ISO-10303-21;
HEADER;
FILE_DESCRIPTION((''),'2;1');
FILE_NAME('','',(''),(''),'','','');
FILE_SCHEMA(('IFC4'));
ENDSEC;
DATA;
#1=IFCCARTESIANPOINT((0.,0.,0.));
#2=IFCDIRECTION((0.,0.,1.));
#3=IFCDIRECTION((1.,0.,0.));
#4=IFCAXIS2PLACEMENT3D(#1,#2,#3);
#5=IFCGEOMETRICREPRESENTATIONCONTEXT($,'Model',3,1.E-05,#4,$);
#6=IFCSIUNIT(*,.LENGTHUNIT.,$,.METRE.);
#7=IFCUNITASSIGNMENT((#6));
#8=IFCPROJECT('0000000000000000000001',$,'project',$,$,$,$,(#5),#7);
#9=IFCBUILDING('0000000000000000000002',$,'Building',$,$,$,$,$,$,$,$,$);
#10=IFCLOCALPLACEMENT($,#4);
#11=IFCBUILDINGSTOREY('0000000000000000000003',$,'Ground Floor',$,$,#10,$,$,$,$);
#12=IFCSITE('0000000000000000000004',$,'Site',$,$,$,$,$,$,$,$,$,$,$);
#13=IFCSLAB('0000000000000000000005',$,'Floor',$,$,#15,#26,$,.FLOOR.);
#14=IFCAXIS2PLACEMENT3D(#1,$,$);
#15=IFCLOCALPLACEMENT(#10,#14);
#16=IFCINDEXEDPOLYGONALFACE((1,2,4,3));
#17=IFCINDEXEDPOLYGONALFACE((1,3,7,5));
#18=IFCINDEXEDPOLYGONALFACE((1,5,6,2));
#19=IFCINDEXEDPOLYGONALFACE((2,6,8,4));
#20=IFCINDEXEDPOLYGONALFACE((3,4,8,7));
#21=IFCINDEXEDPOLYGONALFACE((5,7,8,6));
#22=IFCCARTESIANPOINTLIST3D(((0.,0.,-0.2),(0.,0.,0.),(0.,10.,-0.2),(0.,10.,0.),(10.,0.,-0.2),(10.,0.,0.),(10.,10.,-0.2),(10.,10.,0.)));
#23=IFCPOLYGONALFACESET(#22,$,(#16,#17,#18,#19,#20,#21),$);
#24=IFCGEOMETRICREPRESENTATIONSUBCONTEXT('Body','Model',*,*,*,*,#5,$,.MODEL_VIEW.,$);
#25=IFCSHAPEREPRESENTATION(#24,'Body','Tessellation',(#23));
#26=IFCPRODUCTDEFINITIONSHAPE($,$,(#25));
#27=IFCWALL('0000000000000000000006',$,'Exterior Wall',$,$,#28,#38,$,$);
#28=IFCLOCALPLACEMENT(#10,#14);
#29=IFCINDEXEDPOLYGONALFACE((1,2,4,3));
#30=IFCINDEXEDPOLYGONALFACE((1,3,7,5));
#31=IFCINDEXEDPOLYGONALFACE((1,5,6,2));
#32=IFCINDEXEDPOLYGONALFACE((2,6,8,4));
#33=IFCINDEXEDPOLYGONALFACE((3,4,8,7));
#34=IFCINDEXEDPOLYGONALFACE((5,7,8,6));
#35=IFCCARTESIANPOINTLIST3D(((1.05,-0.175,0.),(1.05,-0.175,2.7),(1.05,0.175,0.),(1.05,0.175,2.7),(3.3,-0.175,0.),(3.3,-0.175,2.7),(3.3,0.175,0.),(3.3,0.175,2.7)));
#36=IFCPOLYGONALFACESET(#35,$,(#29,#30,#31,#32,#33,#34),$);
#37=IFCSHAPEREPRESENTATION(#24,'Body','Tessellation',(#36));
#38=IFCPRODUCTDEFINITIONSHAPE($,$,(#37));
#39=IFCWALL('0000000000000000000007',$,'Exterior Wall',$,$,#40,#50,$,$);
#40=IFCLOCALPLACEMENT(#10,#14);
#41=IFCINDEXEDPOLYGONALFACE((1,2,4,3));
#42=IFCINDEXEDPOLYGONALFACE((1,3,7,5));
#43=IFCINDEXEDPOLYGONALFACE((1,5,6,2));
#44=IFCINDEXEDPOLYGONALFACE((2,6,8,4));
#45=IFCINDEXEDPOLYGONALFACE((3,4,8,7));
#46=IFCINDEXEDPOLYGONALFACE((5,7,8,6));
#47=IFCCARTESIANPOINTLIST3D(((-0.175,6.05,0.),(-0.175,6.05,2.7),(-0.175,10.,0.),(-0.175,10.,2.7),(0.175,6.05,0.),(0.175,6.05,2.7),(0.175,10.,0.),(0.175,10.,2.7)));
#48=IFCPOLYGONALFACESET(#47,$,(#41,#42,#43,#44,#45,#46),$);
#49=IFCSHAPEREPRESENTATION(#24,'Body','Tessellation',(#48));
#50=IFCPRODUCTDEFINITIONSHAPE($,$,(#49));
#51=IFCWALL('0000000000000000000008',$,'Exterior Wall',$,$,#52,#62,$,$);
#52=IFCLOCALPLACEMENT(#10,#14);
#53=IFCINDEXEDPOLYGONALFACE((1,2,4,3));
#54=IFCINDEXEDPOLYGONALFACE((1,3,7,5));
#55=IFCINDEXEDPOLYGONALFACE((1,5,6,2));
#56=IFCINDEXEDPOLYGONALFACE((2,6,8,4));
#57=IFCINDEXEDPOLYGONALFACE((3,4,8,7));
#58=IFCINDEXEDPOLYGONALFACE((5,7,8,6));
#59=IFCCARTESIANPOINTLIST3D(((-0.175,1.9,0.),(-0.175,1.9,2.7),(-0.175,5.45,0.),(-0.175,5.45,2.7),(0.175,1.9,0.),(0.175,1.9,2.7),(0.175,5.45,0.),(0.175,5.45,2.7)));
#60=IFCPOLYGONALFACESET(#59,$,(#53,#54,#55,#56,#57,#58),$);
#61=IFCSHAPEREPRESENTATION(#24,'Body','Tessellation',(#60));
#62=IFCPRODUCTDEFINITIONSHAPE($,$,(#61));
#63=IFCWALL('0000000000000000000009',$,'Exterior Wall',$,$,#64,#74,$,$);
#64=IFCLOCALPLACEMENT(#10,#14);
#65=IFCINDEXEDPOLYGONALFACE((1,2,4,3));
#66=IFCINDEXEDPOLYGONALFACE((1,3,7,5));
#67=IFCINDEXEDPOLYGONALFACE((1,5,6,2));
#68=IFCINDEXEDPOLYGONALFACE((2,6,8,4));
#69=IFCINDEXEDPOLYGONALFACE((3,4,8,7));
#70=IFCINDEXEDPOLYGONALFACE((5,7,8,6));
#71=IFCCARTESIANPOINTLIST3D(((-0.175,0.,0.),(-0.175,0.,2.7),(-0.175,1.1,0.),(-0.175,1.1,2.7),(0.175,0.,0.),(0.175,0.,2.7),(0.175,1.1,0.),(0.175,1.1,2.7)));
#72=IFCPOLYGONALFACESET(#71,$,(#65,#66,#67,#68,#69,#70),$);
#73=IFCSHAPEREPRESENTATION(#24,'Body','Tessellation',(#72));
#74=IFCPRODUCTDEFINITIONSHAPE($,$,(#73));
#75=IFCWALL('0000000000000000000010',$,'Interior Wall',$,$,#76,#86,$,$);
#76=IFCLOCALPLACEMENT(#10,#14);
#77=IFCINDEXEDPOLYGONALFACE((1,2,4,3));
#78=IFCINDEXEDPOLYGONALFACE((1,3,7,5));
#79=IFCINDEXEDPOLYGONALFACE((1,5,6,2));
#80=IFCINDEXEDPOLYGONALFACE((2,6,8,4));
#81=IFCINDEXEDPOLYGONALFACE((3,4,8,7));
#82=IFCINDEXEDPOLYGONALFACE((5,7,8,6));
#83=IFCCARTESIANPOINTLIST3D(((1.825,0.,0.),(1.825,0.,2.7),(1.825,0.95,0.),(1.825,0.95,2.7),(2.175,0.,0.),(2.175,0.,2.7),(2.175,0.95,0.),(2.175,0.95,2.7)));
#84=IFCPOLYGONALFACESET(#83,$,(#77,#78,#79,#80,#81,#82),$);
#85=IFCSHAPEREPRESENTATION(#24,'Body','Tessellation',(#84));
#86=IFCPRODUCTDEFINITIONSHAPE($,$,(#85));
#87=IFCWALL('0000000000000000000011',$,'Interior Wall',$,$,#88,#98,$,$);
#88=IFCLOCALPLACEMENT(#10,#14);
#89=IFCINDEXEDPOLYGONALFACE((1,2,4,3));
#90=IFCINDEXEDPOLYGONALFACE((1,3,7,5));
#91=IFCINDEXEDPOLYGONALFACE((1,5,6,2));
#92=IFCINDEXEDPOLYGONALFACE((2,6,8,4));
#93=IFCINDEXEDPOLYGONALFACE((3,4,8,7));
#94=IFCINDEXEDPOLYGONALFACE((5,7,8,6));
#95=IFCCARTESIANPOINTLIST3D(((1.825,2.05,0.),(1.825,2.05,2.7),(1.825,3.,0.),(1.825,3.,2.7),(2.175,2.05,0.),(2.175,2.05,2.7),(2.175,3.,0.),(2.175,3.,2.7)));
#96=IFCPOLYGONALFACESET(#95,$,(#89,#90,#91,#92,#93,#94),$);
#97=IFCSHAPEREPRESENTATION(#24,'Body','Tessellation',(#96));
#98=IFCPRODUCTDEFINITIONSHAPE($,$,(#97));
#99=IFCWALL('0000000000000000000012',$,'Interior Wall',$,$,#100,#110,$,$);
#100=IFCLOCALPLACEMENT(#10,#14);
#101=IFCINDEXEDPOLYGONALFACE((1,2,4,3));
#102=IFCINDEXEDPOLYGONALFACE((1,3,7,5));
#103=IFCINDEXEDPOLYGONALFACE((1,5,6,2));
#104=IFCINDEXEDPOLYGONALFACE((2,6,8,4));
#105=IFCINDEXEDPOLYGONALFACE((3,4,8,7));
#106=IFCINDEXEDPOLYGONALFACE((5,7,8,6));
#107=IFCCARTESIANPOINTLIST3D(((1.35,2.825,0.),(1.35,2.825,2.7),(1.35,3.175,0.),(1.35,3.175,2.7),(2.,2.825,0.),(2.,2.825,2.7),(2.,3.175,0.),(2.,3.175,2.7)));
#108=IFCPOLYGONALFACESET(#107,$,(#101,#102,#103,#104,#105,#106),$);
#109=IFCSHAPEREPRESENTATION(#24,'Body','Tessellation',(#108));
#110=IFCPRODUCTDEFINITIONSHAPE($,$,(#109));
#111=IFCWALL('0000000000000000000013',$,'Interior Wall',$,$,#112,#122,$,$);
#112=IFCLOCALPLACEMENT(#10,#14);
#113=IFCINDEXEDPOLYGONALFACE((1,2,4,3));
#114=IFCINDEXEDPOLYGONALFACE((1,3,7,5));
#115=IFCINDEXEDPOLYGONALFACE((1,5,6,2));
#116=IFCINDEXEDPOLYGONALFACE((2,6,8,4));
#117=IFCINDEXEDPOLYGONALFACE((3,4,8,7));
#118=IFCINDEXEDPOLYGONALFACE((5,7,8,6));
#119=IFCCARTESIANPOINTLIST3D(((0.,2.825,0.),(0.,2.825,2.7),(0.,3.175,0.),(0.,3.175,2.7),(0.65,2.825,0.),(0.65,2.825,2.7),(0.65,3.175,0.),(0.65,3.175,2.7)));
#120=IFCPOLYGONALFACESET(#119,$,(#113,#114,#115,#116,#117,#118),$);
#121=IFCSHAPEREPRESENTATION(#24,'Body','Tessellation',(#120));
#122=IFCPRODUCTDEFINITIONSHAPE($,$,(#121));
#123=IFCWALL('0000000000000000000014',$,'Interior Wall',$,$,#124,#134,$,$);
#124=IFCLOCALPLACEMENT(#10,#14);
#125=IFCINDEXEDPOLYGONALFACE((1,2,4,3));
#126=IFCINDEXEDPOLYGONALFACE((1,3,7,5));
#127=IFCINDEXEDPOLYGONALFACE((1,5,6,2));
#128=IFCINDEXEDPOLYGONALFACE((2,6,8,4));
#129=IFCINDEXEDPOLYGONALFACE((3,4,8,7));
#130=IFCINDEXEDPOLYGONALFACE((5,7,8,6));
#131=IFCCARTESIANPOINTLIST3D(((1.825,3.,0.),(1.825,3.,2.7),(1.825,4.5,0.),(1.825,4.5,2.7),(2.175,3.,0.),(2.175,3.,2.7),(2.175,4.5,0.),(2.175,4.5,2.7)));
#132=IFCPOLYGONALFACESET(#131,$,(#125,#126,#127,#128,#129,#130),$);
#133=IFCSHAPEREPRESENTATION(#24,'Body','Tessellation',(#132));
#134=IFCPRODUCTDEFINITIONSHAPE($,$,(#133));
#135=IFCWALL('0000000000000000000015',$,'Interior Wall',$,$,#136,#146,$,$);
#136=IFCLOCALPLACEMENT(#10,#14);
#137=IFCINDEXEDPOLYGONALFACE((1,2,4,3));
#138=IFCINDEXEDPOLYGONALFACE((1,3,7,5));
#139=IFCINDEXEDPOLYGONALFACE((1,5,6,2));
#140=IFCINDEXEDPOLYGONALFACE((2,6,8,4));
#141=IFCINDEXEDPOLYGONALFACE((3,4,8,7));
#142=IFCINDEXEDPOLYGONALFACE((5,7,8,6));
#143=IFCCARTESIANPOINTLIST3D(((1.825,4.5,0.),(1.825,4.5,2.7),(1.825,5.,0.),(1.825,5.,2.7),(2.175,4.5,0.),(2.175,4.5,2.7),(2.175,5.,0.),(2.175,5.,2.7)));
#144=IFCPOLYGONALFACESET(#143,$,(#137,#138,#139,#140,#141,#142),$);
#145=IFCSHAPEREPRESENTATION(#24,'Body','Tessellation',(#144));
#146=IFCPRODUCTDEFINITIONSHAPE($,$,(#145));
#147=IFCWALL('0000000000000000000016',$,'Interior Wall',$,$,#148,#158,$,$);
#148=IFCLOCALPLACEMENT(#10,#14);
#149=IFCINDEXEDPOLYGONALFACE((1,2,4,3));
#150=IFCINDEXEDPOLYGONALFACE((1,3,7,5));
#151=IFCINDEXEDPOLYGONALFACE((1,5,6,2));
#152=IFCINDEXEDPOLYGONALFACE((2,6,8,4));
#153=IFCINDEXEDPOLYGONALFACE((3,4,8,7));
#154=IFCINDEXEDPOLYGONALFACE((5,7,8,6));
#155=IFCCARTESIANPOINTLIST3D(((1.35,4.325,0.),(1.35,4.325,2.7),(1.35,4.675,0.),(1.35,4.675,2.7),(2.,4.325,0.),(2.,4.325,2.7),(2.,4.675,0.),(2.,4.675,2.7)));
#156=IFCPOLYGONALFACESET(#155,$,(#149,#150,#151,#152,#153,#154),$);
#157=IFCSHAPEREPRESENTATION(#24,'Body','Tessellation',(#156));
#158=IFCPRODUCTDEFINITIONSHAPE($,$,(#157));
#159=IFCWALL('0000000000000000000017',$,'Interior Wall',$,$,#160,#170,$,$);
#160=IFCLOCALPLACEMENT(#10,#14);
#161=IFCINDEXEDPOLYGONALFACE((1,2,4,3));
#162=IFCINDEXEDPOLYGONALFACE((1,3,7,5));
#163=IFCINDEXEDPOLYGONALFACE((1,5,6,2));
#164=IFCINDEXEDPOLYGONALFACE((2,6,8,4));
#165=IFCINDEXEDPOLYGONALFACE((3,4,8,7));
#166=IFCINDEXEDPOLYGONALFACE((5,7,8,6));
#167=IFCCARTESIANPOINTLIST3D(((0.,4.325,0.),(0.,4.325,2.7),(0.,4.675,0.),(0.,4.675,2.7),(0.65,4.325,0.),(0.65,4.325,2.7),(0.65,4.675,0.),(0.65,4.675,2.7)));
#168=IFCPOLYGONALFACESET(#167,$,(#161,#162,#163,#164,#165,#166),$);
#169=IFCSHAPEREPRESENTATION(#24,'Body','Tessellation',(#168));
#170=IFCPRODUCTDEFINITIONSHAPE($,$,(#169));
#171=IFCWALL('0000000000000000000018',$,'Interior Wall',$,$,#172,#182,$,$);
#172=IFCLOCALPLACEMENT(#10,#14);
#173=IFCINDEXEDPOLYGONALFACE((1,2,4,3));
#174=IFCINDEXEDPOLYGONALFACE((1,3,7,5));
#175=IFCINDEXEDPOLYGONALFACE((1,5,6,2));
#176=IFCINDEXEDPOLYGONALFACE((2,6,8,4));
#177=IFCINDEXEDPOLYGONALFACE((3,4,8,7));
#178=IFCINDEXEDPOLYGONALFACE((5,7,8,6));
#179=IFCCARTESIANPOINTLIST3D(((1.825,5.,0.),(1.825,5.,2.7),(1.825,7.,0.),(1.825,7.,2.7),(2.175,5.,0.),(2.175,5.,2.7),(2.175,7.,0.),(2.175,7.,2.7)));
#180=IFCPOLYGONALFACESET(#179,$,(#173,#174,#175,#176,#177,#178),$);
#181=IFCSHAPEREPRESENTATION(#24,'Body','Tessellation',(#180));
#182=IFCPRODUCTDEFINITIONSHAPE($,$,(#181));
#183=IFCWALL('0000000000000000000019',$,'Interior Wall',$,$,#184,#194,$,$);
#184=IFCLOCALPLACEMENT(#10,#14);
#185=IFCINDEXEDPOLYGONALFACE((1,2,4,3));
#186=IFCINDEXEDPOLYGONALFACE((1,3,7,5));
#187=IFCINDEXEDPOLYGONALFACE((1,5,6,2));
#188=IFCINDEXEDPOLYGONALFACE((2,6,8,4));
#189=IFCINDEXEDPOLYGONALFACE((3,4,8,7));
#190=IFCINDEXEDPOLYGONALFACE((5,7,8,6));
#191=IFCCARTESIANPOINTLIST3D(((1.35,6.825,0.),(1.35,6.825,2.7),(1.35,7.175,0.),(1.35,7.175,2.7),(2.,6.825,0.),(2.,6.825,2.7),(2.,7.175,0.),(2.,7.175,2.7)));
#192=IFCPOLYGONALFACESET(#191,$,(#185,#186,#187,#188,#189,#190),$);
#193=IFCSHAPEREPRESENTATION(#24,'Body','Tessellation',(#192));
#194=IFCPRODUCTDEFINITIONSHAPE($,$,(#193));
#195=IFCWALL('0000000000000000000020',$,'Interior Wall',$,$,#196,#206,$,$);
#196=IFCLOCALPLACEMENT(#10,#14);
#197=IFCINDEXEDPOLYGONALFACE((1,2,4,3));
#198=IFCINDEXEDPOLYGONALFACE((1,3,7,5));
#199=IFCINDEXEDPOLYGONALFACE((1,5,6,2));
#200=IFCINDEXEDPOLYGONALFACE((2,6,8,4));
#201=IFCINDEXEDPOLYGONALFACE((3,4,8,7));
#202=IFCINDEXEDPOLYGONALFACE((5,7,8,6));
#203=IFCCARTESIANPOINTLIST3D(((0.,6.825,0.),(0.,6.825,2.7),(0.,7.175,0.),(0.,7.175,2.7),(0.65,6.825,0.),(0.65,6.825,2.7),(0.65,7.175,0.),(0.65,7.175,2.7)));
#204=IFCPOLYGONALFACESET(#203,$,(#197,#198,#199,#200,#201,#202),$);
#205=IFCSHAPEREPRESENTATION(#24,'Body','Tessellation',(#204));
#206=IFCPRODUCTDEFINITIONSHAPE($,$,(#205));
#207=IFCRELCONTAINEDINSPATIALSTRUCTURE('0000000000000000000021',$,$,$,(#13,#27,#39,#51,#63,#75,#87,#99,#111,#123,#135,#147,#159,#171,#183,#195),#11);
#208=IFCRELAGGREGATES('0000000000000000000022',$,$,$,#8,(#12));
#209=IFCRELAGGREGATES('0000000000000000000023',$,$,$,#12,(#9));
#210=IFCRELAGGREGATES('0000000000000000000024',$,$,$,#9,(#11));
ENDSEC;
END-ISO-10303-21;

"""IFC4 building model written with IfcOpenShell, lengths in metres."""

from ifc_helpers import new_model, si_unit, frame, origin_with_axes, place, context, subcontext, project, spatial, indexed_curve, outline, extrude, element, save


model = new_model("IFC4")

# Units and contexts
model_context = context("Model", 3, precision=1e-05, world=origin_with_axes())
body_context = subcontext(model_context, "Body", "Model", "MODEL_VIEW")
ifc_project = project(units=[si_unit("LENGTHUNIT", "METRE")], contexts=[model_context])

# Site, building, storey
site = spatial("IfcSite", under=ifc_project, Name="Site")
building = spatial("IfcBuilding", under=site, Name="Building")
storey_placement = place(None, origin_with_axes())
storey = spatial("IfcBuildingStorey", under=building, at=storey_placement, Name="Ground Floor")

# Slab
slab_placement = place(storey_placement, frame((0.0, 0.0, -0.2), z_axis=(0.0, 0.0, 1.0), x_axis=(1.0, 0.0, 0.0)))
element("IfcSlab", 1, at=slab_placement, inside=storey, Name="Floor", PredefinedType="FLOOR", context=body_context, shape_type="SweptSolid", body=[
    extrude(outline(indexed_curve([(0.0, 0.0), (10.0, 0.0), (10.0, 10.0), (0.0, 10.0)])), None, (0.0, 0.0, 1.0), 0.2),
])

# Walls
wall_1_placement = place(storey_placement, frame((1.05, 0.0, 0.0), z_axis=(0.0, 0.0, 1.0), x_axis=(1.0, 0.0, 0.0)))
element("IfcWall", 2, at=wall_1_placement, inside=storey, Name="Exterior Wall", context=body_context, shape_type="SweptSolid", body=[
    extrude(outline(indexed_curve([(0.0, 0.0), (0.0, 0.35), (2.25, 0.35), (2.25, 0.0), (0.0, 0.0)], self_intersect=False)), frame((0.0, -0.175, 0.0), z_axis=(0.0, 0.0, 1.0), x_axis=(1.0, 0.0, 0.0)), (0.0, 0.0, 1.0), 2.7),
])
wall_2_placement = place(storey_placement, frame((0.0, 10.0, 0.0), z_axis=(0.0, 0.0, 1.0), x_axis=(0.0, -1.0, 0.0)))
element("IfcWall", 3, at=wall_2_placement, inside=storey, Name="Exterior Wall", context=body_context, shape_type="SweptSolid", body=[
    extrude(outline(indexed_curve([(0.0, 0.0), (0.0, 0.35), (3.95, 0.35), (3.95, 0.0), (0.0, 0.0)], self_intersect=False)), frame((0.0, -0.175, 0.0), z_axis=(0.0, 0.0, 1.0), x_axis=(1.0, 0.0, 0.0)), (0.0, 0.0, 1.0), 2.7),
])
wall_3_placement = place(storey_placement, frame((0.0, 5.45, 0.0), z_axis=(0.0, 0.0, 1.0), x_axis=(0.0, -1.0, 0.0)))
element("IfcWall", 4, at=wall_3_placement, inside=storey, Name="Exterior Wall", context=body_context, shape_type="SweptSolid", body=[
    extrude(outline(indexed_curve([(0.0, 0.0), (0.0, 0.35), (3.55, 0.35), (3.55, 0.0), (0.0, 0.0)], self_intersect=False)), frame((0.0, -0.175, 0.0), z_axis=(0.0, 0.0, 1.0), x_axis=(1.0, 0.0, 0.0)), (0.0, 0.0, 1.0), 2.7),
])
wall_4_placement = place(storey_placement, frame((0.0, 1.1, 0.0), z_axis=(0.0, 0.0, 1.0), x_axis=(0.0, -1.0, 0.0)))
element("IfcWall", 5, at=wall_4_placement, inside=storey, Name="Exterior Wall", context=body_context, shape_type="SweptSolid", body=[
    extrude(outline(indexed_curve([(0.0, 0.0), (0.0, 0.35), (1.1, 0.35), (1.1, 0.0), (0.0, 0.0)], self_intersect=False)), frame((0.0, -0.175, 0.0), z_axis=(0.0, 0.0, 1.0), x_axis=(1.0, 0.0, 0.0)), (0.0, 0.0, 1.0), 2.7),
])
wall_5_placement = place(storey_placement, frame((2.0, 0.0, 0.0), z_axis=(0.0, 0.0, 1.0), x_axis=(0.0, 1.0, 0.0)))
element("IfcWall", 6, at=wall_5_placement, inside=storey, Name="Interior Wall", context=body_context, shape_type="SweptSolid", body=[
    extrude(outline(indexed_curve([(0.0, 0.0), (0.0, 0.35), (0.95, 0.35), (0.95, 0.0), (0.0, 0.0)], self_intersect=False)), frame((0.0, -0.175, 0.0), z_axis=(0.0, 0.0, 1.0), x_axis=(1.0, 0.0, 0.0)), (0.0, 0.0, 1.0), 2.7),
])
wall_6_placement = place(storey_placement, frame((2.0, 2.05, 0.0), z_axis=(0.0, 0.0, 1.0), x_axis=(0.0, 1.0, 0.0)))
element("IfcWall", 7, at=wall_6_placement, inside=storey, Name="Interior Wall", context=body_context, shape_type="SweptSolid", body=[
    extrude(outline(indexed_curve([(0.0, 0.0), (0.0, 0.35), (0.95, 0.35), (0.95, 0.0), (0.0, 0.0)], self_intersect=False)), frame((0.0, -0.175, 0.0), z_axis=(0.0, 0.0, 1.0), x_axis=(1.0, 0.0, 0.0)), (0.0, 0.0, 1.0), 2.7),
])
for number, where, z_axis, x_axis, name in (
    (8, (2.0, 3.0, 0.0), (0.0, 0.0, 1.0), (-1.0, 0.0, 0.0), "Interior Wall"),
    (9, (0.65, 3.0, 0.0), (0.0, 0.0, 1.0), (-1.0, 0.0, 0.0), "Interior Wall"),
):
    element("IfcWall", number, at=place(storey_placement, frame(where, z_axis=z_axis, x_axis=x_axis)), inside=storey, Name=name, context=body_context, shape_type="SweptSolid", body=[
        extrude(outline(indexed_curve([(0.0, 0.0), (0.0, 0.35), (0.65, 0.35), (0.65, 0.0), (0.0, 0.0)], self_intersect=False)), frame((0.0, -0.175, 0.0), z_axis=(0.0, 0.0, 1.0), x_axis=(1.0, 0.0, 0.0)), (0.0, 0.0, 1.0), 2.7),
    ])
wall_7_placement = place(storey_placement, frame((2.0, 4.5, 0.0), z_axis=(0.0, 0.0, 1.0), x_axis=(0.0, -1.0, 0.0)))
element("IfcWall", 10, at=wall_7_placement, inside=storey, Name="Interior Wall", context=body_context, shape_type="SweptSolid", body=[
    extrude(outline(indexed_curve([(0.0, 0.0), (0.0, 0.35), (1.5, 0.35), (1.5, 0.0), (0.0, 0.0)], self_intersect=False)), frame((0.0, -0.175, 0.0), z_axis=(0.0, 0.0, 1.0), x_axis=(1.0, 0.0, 0.0)), (0.0, 0.0, 1.0), 2.7),
])
wall_8_placement = place(storey_placement, frame((2.0, 5.0, 0.0), z_axis=(0.0, 0.0, 1.0), x_axis=(0.0, -1.0, 0.0)))
element("IfcWall", 11, at=wall_8_placement, inside=storey, Name="Interior Wall", context=body_context, shape_type="SweptSolid", body=[
    extrude(outline(indexed_curve([(0.0, 0.0), (0.0, 0.35), (0.5, 0.35), (0.5, 0.0), (0.0, 0.0)], self_intersect=False)), frame((0.0, -0.175, 0.0), z_axis=(0.0, 0.0, 1.0), x_axis=(1.0, 0.0, 0.0)), (0.0, 0.0, 1.0), 2.7),
])
for number, where, z_axis, x_axis, name in (
    (12, (2.0, 4.5, 0.0), (0.0, 0.0, 1.0), (-1.0, 0.0, 0.0), "Interior Wall"),
    (13, (0.65, 4.5, 0.0), (0.0, 0.0, 1.0), (-1.0, 0.0, 0.0), "Interior Wall"),
):
    element("IfcWall", number, at=place(storey_placement, frame(where, z_axis=z_axis, x_axis=x_axis)), inside=storey, Name=name, context=body_context, shape_type="SweptSolid", body=[
        extrude(outline(indexed_curve([(0.0, 0.0), (0.0, 0.35), (0.65, 0.35), (0.65, 0.0), (0.0, 0.0)], self_intersect=False)), frame((0.0, -0.175, 0.0), z_axis=(0.0, 0.0, 1.0), x_axis=(1.0, 0.0, 0.0)), (0.0, 0.0, 1.0), 2.7),
    ])
wall_9_placement = place(storey_placement, frame((2.0, 5.0, 0.0), z_axis=(0.0, 0.0, 1.0), x_axis=(0.0, 1.0, 0.0)))
element("IfcWall", 14, at=wall_9_placement, inside=storey, Name="Interior Wall", context=body_context, shape_type="SweptSolid", body=[
    extrude(outline(indexed_curve([(0.0, 0.0), (0.0, 0.35), (2.0, 0.35), (2.0, 0.0), (0.0, 0.0)], self_intersect=False)), frame((0.0, -0.175, 0.0), z_axis=(0.0, 0.0, 1.0), x_axis=(1.0, 0.0, 0.0)), (0.0, 0.0, 1.0), 2.7),
])
for number, where, z_axis, x_axis, name in (
    (15, (2.0, 7.0, 0.0), (0.0, 0.0, 1.0), (-1.0, 0.0, 0.0), "Interior Wall"),
    (16, (0.65, 7.0, 0.0), (0.0, 0.0, 1.0), (-1.0, 0.0, 0.0), "Interior Wall"),
):
    element("IfcWall", number, at=place(storey_placement, frame(where, z_axis=z_axis, x_axis=x_axis)), inside=storey, Name=name, context=body_context, shape_type="SweptSolid", body=[
        extrude(outline(indexed_curve([(0.0, 0.0), (0.0, 0.35), (0.65, 0.35), (0.65, 0.0), (0.0, 0.0)], self_intersect=False)), frame((0.0, -0.175, 0.0), z_axis=(0.0, 0.0, 1.0), x_axis=(1.0, 0.0, 0.0)), (0.0, 0.0, 1.0), 2.7),
    ])

save(model, "model.ifc")
